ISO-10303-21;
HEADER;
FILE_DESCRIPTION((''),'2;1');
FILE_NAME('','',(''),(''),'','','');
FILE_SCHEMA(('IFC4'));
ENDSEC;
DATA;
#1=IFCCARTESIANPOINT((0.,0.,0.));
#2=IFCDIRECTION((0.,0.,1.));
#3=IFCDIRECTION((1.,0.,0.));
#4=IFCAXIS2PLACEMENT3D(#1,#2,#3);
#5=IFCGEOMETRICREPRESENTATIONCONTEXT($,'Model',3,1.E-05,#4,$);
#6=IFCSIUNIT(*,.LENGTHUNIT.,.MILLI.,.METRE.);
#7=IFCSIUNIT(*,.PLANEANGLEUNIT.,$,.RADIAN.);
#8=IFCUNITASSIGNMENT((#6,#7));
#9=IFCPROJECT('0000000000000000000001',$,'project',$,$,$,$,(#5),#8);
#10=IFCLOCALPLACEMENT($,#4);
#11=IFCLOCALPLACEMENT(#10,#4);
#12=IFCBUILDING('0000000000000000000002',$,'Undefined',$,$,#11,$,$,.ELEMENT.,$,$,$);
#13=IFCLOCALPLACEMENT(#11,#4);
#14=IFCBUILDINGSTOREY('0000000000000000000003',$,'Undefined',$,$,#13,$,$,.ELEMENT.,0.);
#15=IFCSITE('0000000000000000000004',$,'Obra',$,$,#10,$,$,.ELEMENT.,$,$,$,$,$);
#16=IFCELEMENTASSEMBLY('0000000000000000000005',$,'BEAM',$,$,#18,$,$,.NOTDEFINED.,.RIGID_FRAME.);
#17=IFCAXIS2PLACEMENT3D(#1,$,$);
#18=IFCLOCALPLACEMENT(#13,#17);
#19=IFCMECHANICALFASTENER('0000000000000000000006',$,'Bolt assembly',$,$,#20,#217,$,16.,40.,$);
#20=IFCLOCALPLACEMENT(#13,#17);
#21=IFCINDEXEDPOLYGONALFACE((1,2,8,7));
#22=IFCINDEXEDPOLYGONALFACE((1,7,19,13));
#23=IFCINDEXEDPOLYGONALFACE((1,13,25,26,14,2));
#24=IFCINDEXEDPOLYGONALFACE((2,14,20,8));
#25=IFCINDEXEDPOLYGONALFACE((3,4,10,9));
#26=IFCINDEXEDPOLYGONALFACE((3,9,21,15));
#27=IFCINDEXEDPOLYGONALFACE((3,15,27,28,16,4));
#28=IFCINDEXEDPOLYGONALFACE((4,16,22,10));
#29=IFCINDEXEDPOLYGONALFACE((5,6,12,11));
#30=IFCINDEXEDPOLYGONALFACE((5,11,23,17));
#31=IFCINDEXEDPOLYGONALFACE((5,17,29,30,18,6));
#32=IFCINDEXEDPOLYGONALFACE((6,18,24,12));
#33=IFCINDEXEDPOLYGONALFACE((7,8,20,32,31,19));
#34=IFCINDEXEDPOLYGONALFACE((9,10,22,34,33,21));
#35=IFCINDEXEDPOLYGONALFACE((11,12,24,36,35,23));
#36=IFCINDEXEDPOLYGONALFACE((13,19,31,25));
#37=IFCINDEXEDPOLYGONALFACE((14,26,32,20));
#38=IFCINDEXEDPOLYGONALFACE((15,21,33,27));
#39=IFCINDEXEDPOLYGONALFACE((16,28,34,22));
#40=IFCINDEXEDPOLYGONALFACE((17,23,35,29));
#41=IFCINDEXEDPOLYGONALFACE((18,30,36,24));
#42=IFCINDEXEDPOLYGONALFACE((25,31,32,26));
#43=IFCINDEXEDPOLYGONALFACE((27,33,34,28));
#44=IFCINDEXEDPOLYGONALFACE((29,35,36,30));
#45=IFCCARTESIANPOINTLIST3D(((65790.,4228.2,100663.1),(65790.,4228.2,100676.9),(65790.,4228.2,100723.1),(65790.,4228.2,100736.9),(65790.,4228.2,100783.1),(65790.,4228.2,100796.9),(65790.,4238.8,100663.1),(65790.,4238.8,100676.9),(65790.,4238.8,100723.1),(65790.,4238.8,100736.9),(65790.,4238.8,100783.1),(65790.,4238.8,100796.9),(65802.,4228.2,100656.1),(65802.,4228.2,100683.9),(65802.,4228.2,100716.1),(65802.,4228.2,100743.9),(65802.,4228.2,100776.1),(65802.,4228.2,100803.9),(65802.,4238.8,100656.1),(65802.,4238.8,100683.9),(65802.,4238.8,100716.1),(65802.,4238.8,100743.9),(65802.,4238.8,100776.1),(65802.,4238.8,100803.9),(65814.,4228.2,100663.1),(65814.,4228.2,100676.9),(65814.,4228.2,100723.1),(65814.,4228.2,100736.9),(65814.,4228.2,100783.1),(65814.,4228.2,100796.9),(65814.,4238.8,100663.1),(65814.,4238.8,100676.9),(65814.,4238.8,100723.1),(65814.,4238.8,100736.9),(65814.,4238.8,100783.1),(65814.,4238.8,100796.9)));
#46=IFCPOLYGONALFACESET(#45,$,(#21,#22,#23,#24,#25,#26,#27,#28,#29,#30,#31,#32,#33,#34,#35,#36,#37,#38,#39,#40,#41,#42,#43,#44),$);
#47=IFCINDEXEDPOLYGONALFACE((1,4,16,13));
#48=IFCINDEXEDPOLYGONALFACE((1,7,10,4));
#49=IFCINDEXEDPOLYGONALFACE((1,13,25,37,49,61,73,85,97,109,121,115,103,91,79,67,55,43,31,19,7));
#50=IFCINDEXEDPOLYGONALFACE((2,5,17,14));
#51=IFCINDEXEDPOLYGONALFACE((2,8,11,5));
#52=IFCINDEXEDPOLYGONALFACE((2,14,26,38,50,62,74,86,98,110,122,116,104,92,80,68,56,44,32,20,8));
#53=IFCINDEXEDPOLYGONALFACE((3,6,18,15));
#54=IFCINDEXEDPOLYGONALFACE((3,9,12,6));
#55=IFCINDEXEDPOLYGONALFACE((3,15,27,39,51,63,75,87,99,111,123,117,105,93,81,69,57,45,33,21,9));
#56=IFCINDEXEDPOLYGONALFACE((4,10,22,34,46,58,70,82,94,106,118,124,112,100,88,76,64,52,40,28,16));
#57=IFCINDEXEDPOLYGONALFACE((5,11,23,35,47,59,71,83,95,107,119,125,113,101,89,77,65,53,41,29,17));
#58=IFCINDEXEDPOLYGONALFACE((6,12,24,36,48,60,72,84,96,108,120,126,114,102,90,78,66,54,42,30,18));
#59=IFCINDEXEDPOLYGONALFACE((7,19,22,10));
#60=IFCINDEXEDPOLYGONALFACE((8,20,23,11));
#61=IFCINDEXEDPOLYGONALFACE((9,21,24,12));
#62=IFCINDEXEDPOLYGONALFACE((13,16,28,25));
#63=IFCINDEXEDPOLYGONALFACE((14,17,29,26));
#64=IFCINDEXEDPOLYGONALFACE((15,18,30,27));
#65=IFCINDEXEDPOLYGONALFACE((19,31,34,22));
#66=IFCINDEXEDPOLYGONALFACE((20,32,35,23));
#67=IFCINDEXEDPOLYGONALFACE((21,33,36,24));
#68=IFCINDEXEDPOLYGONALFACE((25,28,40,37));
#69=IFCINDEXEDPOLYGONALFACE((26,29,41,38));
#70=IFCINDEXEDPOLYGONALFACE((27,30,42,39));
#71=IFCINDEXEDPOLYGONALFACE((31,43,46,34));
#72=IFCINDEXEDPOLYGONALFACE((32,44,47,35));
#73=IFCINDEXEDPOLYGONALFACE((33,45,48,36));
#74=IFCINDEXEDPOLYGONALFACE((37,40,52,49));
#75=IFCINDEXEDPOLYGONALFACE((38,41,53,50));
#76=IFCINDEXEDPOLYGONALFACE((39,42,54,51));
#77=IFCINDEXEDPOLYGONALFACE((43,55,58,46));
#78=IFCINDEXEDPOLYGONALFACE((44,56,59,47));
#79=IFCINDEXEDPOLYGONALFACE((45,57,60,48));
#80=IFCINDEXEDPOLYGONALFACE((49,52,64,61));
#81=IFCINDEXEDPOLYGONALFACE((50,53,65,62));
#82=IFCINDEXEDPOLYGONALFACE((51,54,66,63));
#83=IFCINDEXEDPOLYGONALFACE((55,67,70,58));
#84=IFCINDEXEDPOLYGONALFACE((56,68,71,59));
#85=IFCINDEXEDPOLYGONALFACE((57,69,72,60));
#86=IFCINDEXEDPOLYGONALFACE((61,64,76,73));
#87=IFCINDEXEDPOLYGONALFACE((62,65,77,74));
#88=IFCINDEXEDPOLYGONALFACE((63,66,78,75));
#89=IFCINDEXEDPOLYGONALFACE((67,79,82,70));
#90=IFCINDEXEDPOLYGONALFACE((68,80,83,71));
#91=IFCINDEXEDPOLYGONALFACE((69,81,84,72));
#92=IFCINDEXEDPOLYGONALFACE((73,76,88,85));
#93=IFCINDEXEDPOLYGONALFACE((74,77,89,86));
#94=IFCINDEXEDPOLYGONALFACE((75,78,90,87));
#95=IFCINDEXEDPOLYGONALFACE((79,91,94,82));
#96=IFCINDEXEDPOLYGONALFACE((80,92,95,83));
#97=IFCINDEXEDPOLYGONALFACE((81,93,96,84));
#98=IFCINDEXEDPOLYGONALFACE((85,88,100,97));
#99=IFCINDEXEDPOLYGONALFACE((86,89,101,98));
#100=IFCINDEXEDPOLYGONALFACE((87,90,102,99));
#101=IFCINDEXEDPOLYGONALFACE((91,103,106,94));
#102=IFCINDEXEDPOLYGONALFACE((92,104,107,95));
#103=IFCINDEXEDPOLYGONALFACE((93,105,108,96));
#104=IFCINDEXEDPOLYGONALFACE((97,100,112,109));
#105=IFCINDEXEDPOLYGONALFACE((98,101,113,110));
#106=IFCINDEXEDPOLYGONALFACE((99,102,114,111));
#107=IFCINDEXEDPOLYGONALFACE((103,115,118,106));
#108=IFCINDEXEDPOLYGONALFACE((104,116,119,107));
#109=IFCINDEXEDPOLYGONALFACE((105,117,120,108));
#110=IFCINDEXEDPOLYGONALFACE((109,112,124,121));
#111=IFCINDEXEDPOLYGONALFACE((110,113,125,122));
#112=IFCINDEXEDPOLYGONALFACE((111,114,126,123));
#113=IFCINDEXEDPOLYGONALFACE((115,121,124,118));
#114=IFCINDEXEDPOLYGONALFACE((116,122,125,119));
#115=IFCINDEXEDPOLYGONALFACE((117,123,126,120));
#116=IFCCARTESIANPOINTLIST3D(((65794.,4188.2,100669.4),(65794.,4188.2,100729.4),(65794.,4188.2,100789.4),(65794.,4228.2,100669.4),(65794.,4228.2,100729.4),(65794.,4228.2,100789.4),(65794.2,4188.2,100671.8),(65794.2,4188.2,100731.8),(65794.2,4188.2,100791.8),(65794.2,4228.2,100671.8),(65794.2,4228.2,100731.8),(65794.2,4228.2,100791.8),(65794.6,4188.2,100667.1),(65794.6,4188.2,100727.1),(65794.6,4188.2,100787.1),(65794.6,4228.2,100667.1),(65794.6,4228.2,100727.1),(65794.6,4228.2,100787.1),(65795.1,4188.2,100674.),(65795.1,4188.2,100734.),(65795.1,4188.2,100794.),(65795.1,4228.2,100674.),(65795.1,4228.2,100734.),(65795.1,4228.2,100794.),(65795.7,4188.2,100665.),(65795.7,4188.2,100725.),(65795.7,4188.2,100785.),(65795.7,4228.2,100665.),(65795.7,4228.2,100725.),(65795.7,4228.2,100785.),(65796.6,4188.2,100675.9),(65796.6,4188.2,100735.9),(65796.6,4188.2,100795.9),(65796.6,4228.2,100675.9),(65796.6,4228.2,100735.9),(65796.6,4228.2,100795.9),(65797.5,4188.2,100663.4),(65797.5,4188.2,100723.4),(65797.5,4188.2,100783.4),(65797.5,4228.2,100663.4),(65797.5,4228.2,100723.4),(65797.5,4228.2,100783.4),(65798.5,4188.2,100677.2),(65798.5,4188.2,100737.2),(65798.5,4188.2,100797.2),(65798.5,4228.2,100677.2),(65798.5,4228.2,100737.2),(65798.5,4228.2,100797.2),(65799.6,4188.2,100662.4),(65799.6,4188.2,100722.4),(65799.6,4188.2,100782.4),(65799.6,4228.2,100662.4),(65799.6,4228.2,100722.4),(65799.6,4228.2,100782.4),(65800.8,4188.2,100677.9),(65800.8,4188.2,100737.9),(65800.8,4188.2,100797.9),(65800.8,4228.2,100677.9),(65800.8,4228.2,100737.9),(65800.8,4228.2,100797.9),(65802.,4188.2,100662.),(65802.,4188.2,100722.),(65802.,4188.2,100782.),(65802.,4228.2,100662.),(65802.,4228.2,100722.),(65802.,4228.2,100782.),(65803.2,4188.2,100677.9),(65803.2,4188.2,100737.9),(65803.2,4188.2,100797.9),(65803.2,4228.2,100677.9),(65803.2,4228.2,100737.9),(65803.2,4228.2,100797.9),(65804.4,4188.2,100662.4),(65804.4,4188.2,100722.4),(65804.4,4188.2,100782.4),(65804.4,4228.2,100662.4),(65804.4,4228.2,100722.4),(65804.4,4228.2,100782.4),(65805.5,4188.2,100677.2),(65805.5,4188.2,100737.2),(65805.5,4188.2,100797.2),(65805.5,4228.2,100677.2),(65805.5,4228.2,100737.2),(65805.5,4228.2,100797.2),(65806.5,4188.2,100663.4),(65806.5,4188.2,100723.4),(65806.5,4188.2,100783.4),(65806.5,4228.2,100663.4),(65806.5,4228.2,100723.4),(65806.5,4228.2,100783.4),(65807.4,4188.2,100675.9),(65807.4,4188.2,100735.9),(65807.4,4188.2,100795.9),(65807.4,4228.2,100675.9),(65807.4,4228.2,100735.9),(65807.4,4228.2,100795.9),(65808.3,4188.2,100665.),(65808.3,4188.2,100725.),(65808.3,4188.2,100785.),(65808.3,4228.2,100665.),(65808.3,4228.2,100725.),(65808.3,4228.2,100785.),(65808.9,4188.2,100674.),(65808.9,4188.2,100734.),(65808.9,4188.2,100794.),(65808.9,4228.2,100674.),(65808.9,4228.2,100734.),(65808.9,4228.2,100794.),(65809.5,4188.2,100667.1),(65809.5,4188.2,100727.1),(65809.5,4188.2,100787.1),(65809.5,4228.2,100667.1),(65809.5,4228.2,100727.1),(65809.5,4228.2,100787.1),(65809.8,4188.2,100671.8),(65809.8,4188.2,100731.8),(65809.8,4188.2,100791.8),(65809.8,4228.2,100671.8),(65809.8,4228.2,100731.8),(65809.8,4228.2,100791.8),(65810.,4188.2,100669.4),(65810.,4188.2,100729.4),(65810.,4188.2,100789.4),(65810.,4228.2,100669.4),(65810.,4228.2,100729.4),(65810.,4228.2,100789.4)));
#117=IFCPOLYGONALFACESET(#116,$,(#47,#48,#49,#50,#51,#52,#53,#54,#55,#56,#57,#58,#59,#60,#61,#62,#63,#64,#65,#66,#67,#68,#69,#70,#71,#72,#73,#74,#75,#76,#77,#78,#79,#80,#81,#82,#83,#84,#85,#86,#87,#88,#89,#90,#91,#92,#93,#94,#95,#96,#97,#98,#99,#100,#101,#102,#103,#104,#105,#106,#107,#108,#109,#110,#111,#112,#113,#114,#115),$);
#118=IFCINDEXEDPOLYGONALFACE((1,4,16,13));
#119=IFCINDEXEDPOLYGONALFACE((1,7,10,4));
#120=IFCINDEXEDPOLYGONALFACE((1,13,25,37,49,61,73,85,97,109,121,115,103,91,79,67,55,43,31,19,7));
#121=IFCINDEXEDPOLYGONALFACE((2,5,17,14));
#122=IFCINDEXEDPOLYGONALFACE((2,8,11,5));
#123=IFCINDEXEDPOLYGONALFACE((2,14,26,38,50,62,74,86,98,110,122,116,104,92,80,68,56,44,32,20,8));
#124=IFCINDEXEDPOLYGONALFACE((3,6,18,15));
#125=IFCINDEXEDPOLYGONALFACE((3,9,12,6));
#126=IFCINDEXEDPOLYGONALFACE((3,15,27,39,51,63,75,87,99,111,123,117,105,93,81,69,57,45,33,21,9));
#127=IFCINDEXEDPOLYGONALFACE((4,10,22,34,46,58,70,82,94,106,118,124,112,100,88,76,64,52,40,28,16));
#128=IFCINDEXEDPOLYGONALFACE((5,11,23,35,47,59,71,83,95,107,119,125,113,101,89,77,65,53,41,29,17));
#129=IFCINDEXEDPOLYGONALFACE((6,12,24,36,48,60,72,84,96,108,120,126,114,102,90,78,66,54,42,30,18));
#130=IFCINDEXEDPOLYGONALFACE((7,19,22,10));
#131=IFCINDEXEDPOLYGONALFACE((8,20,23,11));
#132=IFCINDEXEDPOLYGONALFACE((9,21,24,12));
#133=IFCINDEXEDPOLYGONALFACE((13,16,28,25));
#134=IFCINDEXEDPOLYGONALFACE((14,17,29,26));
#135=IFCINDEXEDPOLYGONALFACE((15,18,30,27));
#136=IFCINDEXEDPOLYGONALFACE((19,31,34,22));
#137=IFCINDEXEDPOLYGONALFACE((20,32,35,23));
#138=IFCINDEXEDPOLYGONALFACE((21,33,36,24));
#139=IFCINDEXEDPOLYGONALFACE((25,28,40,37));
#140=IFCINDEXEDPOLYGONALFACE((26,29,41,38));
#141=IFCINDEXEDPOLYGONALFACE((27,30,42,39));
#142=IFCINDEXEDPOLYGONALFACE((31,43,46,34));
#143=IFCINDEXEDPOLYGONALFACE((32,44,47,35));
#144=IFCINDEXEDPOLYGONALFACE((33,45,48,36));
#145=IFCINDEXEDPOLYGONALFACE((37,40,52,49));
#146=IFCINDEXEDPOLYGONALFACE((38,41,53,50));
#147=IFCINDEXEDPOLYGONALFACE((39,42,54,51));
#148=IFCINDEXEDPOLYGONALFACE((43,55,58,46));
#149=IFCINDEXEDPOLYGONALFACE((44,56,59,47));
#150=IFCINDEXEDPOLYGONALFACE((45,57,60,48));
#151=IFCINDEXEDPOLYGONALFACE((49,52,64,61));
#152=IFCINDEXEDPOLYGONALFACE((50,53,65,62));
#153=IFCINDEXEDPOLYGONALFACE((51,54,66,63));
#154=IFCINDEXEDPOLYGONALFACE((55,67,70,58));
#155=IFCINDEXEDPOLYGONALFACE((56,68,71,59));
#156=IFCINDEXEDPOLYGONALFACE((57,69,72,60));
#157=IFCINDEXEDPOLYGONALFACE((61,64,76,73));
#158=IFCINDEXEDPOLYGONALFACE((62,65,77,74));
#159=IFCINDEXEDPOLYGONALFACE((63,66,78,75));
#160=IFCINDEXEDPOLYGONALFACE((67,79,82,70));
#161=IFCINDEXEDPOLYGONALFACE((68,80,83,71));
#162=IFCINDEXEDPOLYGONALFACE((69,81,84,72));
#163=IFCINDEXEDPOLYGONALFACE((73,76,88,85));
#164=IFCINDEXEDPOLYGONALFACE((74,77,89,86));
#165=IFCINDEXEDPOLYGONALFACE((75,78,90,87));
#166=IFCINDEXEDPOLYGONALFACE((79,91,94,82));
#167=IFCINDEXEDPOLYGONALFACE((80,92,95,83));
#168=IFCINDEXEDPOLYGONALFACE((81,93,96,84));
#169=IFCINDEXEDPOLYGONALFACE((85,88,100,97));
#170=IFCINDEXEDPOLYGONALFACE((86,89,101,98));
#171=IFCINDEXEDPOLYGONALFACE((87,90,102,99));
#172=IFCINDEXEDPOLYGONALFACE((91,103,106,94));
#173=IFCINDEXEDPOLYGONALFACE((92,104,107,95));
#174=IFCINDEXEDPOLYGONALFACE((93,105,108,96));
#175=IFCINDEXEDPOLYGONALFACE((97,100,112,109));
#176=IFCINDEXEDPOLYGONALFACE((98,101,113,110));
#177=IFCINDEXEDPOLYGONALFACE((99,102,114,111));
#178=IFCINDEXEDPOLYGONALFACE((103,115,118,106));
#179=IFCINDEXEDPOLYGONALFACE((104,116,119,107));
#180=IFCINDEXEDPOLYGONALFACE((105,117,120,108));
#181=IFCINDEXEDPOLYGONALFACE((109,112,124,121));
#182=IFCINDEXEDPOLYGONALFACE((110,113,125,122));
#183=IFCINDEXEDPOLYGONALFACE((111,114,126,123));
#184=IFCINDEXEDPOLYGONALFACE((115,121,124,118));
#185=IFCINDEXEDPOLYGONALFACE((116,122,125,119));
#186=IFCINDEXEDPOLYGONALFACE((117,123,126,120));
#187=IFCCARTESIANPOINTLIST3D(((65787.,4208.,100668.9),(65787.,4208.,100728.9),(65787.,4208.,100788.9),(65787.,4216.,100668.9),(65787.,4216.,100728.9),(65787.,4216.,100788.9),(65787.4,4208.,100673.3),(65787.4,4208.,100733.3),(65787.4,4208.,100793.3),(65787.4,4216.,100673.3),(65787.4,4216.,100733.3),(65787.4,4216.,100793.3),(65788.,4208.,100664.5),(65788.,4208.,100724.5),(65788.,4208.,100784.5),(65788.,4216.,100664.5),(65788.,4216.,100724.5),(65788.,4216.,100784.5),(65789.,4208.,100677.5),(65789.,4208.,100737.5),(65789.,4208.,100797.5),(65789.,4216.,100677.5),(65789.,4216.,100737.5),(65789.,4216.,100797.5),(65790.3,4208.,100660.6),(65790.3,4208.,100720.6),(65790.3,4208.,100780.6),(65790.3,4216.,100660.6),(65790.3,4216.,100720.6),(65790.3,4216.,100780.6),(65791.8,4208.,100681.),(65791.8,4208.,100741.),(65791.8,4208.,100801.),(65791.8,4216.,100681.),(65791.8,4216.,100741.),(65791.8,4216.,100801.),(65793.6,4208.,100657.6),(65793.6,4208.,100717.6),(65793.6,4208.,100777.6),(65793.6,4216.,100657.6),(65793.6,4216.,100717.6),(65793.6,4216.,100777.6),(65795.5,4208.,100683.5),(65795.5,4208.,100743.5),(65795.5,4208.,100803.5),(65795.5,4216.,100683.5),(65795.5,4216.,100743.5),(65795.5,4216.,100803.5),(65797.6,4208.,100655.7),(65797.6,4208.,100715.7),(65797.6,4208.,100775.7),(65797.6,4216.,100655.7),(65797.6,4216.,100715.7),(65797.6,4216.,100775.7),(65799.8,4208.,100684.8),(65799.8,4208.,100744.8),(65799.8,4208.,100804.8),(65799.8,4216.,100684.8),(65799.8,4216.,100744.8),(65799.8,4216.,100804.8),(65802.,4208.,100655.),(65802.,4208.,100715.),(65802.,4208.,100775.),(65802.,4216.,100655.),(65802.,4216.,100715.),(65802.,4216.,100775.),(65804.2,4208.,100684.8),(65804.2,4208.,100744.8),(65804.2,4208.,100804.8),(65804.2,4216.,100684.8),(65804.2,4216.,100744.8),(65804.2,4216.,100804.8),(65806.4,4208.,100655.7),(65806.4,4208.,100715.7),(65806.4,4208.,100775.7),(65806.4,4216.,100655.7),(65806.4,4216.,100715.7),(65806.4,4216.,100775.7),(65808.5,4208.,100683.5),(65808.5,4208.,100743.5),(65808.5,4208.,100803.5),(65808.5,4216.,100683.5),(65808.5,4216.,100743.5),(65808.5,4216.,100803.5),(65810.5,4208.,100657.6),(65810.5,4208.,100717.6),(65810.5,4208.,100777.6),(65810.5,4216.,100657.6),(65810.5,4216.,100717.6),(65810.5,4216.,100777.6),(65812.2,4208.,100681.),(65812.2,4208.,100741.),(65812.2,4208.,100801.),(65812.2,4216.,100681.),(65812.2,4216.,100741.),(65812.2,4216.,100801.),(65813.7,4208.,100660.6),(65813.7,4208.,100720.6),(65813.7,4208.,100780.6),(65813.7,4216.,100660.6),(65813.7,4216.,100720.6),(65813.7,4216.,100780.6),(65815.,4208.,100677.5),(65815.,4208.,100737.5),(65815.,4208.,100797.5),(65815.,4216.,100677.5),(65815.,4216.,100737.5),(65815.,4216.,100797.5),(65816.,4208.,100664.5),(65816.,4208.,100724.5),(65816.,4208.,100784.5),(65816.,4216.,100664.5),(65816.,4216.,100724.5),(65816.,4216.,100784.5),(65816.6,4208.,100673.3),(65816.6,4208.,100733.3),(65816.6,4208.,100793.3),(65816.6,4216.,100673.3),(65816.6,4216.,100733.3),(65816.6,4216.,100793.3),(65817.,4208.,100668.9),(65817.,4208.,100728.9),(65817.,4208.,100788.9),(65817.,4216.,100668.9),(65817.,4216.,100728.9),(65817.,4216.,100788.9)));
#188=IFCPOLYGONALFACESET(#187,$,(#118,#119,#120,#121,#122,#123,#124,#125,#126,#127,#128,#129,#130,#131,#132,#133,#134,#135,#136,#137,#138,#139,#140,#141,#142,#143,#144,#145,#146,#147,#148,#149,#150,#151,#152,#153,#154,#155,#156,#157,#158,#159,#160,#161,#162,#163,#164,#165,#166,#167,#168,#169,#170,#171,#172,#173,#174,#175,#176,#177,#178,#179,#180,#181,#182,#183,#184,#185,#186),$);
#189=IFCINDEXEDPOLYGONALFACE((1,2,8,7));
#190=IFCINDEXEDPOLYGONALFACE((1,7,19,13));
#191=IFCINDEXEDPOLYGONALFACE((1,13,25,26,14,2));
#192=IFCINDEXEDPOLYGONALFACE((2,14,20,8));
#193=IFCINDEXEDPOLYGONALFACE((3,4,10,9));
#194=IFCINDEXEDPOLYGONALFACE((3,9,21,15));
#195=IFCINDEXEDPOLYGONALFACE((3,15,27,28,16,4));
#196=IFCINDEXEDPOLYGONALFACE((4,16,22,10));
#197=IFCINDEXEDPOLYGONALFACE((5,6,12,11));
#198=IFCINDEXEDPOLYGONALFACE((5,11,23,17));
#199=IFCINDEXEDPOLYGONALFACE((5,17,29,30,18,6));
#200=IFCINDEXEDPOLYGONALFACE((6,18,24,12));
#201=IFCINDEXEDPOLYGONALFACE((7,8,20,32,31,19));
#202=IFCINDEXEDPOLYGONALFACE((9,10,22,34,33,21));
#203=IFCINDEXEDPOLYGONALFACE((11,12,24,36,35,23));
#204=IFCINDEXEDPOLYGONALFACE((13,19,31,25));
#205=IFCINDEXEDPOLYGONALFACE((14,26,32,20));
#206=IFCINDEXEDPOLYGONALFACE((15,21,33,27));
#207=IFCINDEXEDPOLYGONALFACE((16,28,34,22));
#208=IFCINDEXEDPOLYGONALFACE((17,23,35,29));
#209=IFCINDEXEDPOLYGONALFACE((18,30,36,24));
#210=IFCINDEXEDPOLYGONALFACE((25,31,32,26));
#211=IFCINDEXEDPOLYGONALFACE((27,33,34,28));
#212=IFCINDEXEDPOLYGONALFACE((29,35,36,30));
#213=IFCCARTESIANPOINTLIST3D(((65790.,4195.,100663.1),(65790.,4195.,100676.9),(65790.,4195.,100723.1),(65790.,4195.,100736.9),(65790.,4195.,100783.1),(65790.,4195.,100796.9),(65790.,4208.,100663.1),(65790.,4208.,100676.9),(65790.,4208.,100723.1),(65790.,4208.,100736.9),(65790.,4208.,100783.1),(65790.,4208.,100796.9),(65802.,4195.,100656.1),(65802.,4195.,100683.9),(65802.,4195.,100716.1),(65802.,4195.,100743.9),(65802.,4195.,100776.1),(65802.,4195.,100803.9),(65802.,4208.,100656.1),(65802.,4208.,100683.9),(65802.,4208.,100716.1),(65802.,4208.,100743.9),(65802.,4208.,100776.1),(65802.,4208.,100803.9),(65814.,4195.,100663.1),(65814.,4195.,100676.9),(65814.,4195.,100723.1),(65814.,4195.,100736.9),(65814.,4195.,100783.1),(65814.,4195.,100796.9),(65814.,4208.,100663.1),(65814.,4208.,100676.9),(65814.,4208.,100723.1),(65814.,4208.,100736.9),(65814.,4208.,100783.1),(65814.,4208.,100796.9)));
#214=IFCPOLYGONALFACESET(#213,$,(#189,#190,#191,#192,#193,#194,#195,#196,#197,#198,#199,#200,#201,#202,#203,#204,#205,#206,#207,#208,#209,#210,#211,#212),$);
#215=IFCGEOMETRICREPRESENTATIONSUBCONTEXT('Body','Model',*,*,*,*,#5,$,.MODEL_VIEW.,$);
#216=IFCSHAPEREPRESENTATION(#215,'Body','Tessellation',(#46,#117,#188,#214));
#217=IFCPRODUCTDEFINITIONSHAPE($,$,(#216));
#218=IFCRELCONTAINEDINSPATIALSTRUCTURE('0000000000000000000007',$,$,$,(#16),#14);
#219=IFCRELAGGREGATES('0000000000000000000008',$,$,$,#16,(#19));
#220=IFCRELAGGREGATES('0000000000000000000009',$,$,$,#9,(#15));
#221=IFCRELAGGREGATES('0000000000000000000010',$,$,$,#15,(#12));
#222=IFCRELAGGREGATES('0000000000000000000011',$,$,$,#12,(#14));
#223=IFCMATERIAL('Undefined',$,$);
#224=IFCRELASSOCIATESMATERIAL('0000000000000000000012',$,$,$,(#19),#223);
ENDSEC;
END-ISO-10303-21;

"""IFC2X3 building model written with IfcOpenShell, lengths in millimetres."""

from ifc_helpers import new_model, si_unit, frame, origin_with_axes, origin_2d_with_axis, place, context, subcontext, project, spatial, polyline, circle, outline, extrude, source, transform, mapped, material, element, aggregate, save


model = new_model("IFC2X3")

# Units and contexts
model_context = context("Model", 3, precision=1e-05, world=origin_with_axes())
body_context = subcontext(model_context, "Body", "Model", "MODEL_VIEW")
ifc_project = project(units=[si_unit("LENGTHUNIT", "METRE", prefix="MILLI"), si_unit("PLANEANGLEUNIT", "RADIAN")], contexts=[model_context])

# Site, building, storey
site_placement = place(None, origin_with_axes())
site = spatial("IfcSite", under=ifc_project, at=site_placement, Name="Obra", CompositionType="ELEMENT")
building_placement = place(site_placement, origin_with_axes())
building = spatial("IfcBuilding", under=site, at=building_placement, Name="Undefined", CompositionType="ELEMENT")
storey_placement = place(building_placement, origin_with_axes())
storey = spatial("IfcBuildingStorey", under=building, at=storey_placement, Name="Undefined", CompositionType="ELEMENT", Elevation=0.0)

# Shared definitions
ifc_material_1 = material(Name="Undefined")

# Shared definitions
shared_shape_1 = source(origin_with_axes(), body_context, "Body", "SweptSolid", [
    extrude(outline(polyline([(13.9, 0.0), (6.9, 12.0), (-6.9, 12.0), (-13.9, 0.0), (-6.9, -12.0), (6.9, -12.0), (13.9, 0.0)])), frame((0.0, -19.7, 0.0), z_axis=(0.0, 1.0, 0.0), x_axis=(1.0, 0.0, 0.0)), (0.0, 0.0, 1.0), 10.6),
    extrude(circle(Radius=8.0, at=origin_2d_with_axis()), frame((0.0, -9.1, 0.0), z_axis=(0.0, 1.0, 0.0), x_axis=(1.0, 0.0, 0.0)), (0.0, 0.0, 1.0), 40.0),
    extrude(circle(Radius=15.0, at=origin_2d_with_axis()), frame((0.0, 3.1, 0.0), z_axis=(0.0, 1.0, 0.0), x_axis=(1.0, 0.0, 0.0)), (0.0, 0.0, 1.0), 8.0),
    extrude(outline(polyline([(13.9, 0.0), (6.9, 12.0), (-6.9, 12.0), (-13.9, 0.0), (-6.9, -12.0), (6.9, -12.0), (13.9, 0.0)])), frame((0.0, 11.1, 0.0), z_axis=(0.0, 1.0, 0.0), x_axis=(1.0, 0.0, 0.0)), (0.0, 0.0, 1.0), 13.0),
])

# Element assembly, mechanical fastener
assembly_1_placement = place(storey_placement, origin_with_axes())
assembly_1 = element("IfcElementAssembly", 1, at=assembly_1_placement, inside=storey, Name="BEAM", AssemblyPlace="NOTDEFINED", PredefinedType="RIGID_FRAME")
mechanical_fastener_1_placement = place(assembly_1_placement, frame((65852.0, 4219.1, 100850.0), z_axis=(-1.0, 0.0, 0.0), x_axis=(0.0, 0.0, -1.0)))
mechanical_fastener_1 = element("IfcMechanicalFastener", 2, at=mechanical_fastener_1_placement, material=ifc_material_1, Name="Bolt assembly", NominalDiameter=16.0, NominalLength=40.0, context=body_context, shape_type="MappedRepresentation", body=[
    mapped(shared_shape_1, transform((60.0, 0.0, 50.0))),
    mapped(shared_shape_1, transform((120.0, 0.0, 50.0))),
    mapped(shared_shape_1, transform((180.0, 0.0, 50.0))),
])

aggregate(assembly_1, [mechanical_fastener_1])

save(model, "model.ifc")
